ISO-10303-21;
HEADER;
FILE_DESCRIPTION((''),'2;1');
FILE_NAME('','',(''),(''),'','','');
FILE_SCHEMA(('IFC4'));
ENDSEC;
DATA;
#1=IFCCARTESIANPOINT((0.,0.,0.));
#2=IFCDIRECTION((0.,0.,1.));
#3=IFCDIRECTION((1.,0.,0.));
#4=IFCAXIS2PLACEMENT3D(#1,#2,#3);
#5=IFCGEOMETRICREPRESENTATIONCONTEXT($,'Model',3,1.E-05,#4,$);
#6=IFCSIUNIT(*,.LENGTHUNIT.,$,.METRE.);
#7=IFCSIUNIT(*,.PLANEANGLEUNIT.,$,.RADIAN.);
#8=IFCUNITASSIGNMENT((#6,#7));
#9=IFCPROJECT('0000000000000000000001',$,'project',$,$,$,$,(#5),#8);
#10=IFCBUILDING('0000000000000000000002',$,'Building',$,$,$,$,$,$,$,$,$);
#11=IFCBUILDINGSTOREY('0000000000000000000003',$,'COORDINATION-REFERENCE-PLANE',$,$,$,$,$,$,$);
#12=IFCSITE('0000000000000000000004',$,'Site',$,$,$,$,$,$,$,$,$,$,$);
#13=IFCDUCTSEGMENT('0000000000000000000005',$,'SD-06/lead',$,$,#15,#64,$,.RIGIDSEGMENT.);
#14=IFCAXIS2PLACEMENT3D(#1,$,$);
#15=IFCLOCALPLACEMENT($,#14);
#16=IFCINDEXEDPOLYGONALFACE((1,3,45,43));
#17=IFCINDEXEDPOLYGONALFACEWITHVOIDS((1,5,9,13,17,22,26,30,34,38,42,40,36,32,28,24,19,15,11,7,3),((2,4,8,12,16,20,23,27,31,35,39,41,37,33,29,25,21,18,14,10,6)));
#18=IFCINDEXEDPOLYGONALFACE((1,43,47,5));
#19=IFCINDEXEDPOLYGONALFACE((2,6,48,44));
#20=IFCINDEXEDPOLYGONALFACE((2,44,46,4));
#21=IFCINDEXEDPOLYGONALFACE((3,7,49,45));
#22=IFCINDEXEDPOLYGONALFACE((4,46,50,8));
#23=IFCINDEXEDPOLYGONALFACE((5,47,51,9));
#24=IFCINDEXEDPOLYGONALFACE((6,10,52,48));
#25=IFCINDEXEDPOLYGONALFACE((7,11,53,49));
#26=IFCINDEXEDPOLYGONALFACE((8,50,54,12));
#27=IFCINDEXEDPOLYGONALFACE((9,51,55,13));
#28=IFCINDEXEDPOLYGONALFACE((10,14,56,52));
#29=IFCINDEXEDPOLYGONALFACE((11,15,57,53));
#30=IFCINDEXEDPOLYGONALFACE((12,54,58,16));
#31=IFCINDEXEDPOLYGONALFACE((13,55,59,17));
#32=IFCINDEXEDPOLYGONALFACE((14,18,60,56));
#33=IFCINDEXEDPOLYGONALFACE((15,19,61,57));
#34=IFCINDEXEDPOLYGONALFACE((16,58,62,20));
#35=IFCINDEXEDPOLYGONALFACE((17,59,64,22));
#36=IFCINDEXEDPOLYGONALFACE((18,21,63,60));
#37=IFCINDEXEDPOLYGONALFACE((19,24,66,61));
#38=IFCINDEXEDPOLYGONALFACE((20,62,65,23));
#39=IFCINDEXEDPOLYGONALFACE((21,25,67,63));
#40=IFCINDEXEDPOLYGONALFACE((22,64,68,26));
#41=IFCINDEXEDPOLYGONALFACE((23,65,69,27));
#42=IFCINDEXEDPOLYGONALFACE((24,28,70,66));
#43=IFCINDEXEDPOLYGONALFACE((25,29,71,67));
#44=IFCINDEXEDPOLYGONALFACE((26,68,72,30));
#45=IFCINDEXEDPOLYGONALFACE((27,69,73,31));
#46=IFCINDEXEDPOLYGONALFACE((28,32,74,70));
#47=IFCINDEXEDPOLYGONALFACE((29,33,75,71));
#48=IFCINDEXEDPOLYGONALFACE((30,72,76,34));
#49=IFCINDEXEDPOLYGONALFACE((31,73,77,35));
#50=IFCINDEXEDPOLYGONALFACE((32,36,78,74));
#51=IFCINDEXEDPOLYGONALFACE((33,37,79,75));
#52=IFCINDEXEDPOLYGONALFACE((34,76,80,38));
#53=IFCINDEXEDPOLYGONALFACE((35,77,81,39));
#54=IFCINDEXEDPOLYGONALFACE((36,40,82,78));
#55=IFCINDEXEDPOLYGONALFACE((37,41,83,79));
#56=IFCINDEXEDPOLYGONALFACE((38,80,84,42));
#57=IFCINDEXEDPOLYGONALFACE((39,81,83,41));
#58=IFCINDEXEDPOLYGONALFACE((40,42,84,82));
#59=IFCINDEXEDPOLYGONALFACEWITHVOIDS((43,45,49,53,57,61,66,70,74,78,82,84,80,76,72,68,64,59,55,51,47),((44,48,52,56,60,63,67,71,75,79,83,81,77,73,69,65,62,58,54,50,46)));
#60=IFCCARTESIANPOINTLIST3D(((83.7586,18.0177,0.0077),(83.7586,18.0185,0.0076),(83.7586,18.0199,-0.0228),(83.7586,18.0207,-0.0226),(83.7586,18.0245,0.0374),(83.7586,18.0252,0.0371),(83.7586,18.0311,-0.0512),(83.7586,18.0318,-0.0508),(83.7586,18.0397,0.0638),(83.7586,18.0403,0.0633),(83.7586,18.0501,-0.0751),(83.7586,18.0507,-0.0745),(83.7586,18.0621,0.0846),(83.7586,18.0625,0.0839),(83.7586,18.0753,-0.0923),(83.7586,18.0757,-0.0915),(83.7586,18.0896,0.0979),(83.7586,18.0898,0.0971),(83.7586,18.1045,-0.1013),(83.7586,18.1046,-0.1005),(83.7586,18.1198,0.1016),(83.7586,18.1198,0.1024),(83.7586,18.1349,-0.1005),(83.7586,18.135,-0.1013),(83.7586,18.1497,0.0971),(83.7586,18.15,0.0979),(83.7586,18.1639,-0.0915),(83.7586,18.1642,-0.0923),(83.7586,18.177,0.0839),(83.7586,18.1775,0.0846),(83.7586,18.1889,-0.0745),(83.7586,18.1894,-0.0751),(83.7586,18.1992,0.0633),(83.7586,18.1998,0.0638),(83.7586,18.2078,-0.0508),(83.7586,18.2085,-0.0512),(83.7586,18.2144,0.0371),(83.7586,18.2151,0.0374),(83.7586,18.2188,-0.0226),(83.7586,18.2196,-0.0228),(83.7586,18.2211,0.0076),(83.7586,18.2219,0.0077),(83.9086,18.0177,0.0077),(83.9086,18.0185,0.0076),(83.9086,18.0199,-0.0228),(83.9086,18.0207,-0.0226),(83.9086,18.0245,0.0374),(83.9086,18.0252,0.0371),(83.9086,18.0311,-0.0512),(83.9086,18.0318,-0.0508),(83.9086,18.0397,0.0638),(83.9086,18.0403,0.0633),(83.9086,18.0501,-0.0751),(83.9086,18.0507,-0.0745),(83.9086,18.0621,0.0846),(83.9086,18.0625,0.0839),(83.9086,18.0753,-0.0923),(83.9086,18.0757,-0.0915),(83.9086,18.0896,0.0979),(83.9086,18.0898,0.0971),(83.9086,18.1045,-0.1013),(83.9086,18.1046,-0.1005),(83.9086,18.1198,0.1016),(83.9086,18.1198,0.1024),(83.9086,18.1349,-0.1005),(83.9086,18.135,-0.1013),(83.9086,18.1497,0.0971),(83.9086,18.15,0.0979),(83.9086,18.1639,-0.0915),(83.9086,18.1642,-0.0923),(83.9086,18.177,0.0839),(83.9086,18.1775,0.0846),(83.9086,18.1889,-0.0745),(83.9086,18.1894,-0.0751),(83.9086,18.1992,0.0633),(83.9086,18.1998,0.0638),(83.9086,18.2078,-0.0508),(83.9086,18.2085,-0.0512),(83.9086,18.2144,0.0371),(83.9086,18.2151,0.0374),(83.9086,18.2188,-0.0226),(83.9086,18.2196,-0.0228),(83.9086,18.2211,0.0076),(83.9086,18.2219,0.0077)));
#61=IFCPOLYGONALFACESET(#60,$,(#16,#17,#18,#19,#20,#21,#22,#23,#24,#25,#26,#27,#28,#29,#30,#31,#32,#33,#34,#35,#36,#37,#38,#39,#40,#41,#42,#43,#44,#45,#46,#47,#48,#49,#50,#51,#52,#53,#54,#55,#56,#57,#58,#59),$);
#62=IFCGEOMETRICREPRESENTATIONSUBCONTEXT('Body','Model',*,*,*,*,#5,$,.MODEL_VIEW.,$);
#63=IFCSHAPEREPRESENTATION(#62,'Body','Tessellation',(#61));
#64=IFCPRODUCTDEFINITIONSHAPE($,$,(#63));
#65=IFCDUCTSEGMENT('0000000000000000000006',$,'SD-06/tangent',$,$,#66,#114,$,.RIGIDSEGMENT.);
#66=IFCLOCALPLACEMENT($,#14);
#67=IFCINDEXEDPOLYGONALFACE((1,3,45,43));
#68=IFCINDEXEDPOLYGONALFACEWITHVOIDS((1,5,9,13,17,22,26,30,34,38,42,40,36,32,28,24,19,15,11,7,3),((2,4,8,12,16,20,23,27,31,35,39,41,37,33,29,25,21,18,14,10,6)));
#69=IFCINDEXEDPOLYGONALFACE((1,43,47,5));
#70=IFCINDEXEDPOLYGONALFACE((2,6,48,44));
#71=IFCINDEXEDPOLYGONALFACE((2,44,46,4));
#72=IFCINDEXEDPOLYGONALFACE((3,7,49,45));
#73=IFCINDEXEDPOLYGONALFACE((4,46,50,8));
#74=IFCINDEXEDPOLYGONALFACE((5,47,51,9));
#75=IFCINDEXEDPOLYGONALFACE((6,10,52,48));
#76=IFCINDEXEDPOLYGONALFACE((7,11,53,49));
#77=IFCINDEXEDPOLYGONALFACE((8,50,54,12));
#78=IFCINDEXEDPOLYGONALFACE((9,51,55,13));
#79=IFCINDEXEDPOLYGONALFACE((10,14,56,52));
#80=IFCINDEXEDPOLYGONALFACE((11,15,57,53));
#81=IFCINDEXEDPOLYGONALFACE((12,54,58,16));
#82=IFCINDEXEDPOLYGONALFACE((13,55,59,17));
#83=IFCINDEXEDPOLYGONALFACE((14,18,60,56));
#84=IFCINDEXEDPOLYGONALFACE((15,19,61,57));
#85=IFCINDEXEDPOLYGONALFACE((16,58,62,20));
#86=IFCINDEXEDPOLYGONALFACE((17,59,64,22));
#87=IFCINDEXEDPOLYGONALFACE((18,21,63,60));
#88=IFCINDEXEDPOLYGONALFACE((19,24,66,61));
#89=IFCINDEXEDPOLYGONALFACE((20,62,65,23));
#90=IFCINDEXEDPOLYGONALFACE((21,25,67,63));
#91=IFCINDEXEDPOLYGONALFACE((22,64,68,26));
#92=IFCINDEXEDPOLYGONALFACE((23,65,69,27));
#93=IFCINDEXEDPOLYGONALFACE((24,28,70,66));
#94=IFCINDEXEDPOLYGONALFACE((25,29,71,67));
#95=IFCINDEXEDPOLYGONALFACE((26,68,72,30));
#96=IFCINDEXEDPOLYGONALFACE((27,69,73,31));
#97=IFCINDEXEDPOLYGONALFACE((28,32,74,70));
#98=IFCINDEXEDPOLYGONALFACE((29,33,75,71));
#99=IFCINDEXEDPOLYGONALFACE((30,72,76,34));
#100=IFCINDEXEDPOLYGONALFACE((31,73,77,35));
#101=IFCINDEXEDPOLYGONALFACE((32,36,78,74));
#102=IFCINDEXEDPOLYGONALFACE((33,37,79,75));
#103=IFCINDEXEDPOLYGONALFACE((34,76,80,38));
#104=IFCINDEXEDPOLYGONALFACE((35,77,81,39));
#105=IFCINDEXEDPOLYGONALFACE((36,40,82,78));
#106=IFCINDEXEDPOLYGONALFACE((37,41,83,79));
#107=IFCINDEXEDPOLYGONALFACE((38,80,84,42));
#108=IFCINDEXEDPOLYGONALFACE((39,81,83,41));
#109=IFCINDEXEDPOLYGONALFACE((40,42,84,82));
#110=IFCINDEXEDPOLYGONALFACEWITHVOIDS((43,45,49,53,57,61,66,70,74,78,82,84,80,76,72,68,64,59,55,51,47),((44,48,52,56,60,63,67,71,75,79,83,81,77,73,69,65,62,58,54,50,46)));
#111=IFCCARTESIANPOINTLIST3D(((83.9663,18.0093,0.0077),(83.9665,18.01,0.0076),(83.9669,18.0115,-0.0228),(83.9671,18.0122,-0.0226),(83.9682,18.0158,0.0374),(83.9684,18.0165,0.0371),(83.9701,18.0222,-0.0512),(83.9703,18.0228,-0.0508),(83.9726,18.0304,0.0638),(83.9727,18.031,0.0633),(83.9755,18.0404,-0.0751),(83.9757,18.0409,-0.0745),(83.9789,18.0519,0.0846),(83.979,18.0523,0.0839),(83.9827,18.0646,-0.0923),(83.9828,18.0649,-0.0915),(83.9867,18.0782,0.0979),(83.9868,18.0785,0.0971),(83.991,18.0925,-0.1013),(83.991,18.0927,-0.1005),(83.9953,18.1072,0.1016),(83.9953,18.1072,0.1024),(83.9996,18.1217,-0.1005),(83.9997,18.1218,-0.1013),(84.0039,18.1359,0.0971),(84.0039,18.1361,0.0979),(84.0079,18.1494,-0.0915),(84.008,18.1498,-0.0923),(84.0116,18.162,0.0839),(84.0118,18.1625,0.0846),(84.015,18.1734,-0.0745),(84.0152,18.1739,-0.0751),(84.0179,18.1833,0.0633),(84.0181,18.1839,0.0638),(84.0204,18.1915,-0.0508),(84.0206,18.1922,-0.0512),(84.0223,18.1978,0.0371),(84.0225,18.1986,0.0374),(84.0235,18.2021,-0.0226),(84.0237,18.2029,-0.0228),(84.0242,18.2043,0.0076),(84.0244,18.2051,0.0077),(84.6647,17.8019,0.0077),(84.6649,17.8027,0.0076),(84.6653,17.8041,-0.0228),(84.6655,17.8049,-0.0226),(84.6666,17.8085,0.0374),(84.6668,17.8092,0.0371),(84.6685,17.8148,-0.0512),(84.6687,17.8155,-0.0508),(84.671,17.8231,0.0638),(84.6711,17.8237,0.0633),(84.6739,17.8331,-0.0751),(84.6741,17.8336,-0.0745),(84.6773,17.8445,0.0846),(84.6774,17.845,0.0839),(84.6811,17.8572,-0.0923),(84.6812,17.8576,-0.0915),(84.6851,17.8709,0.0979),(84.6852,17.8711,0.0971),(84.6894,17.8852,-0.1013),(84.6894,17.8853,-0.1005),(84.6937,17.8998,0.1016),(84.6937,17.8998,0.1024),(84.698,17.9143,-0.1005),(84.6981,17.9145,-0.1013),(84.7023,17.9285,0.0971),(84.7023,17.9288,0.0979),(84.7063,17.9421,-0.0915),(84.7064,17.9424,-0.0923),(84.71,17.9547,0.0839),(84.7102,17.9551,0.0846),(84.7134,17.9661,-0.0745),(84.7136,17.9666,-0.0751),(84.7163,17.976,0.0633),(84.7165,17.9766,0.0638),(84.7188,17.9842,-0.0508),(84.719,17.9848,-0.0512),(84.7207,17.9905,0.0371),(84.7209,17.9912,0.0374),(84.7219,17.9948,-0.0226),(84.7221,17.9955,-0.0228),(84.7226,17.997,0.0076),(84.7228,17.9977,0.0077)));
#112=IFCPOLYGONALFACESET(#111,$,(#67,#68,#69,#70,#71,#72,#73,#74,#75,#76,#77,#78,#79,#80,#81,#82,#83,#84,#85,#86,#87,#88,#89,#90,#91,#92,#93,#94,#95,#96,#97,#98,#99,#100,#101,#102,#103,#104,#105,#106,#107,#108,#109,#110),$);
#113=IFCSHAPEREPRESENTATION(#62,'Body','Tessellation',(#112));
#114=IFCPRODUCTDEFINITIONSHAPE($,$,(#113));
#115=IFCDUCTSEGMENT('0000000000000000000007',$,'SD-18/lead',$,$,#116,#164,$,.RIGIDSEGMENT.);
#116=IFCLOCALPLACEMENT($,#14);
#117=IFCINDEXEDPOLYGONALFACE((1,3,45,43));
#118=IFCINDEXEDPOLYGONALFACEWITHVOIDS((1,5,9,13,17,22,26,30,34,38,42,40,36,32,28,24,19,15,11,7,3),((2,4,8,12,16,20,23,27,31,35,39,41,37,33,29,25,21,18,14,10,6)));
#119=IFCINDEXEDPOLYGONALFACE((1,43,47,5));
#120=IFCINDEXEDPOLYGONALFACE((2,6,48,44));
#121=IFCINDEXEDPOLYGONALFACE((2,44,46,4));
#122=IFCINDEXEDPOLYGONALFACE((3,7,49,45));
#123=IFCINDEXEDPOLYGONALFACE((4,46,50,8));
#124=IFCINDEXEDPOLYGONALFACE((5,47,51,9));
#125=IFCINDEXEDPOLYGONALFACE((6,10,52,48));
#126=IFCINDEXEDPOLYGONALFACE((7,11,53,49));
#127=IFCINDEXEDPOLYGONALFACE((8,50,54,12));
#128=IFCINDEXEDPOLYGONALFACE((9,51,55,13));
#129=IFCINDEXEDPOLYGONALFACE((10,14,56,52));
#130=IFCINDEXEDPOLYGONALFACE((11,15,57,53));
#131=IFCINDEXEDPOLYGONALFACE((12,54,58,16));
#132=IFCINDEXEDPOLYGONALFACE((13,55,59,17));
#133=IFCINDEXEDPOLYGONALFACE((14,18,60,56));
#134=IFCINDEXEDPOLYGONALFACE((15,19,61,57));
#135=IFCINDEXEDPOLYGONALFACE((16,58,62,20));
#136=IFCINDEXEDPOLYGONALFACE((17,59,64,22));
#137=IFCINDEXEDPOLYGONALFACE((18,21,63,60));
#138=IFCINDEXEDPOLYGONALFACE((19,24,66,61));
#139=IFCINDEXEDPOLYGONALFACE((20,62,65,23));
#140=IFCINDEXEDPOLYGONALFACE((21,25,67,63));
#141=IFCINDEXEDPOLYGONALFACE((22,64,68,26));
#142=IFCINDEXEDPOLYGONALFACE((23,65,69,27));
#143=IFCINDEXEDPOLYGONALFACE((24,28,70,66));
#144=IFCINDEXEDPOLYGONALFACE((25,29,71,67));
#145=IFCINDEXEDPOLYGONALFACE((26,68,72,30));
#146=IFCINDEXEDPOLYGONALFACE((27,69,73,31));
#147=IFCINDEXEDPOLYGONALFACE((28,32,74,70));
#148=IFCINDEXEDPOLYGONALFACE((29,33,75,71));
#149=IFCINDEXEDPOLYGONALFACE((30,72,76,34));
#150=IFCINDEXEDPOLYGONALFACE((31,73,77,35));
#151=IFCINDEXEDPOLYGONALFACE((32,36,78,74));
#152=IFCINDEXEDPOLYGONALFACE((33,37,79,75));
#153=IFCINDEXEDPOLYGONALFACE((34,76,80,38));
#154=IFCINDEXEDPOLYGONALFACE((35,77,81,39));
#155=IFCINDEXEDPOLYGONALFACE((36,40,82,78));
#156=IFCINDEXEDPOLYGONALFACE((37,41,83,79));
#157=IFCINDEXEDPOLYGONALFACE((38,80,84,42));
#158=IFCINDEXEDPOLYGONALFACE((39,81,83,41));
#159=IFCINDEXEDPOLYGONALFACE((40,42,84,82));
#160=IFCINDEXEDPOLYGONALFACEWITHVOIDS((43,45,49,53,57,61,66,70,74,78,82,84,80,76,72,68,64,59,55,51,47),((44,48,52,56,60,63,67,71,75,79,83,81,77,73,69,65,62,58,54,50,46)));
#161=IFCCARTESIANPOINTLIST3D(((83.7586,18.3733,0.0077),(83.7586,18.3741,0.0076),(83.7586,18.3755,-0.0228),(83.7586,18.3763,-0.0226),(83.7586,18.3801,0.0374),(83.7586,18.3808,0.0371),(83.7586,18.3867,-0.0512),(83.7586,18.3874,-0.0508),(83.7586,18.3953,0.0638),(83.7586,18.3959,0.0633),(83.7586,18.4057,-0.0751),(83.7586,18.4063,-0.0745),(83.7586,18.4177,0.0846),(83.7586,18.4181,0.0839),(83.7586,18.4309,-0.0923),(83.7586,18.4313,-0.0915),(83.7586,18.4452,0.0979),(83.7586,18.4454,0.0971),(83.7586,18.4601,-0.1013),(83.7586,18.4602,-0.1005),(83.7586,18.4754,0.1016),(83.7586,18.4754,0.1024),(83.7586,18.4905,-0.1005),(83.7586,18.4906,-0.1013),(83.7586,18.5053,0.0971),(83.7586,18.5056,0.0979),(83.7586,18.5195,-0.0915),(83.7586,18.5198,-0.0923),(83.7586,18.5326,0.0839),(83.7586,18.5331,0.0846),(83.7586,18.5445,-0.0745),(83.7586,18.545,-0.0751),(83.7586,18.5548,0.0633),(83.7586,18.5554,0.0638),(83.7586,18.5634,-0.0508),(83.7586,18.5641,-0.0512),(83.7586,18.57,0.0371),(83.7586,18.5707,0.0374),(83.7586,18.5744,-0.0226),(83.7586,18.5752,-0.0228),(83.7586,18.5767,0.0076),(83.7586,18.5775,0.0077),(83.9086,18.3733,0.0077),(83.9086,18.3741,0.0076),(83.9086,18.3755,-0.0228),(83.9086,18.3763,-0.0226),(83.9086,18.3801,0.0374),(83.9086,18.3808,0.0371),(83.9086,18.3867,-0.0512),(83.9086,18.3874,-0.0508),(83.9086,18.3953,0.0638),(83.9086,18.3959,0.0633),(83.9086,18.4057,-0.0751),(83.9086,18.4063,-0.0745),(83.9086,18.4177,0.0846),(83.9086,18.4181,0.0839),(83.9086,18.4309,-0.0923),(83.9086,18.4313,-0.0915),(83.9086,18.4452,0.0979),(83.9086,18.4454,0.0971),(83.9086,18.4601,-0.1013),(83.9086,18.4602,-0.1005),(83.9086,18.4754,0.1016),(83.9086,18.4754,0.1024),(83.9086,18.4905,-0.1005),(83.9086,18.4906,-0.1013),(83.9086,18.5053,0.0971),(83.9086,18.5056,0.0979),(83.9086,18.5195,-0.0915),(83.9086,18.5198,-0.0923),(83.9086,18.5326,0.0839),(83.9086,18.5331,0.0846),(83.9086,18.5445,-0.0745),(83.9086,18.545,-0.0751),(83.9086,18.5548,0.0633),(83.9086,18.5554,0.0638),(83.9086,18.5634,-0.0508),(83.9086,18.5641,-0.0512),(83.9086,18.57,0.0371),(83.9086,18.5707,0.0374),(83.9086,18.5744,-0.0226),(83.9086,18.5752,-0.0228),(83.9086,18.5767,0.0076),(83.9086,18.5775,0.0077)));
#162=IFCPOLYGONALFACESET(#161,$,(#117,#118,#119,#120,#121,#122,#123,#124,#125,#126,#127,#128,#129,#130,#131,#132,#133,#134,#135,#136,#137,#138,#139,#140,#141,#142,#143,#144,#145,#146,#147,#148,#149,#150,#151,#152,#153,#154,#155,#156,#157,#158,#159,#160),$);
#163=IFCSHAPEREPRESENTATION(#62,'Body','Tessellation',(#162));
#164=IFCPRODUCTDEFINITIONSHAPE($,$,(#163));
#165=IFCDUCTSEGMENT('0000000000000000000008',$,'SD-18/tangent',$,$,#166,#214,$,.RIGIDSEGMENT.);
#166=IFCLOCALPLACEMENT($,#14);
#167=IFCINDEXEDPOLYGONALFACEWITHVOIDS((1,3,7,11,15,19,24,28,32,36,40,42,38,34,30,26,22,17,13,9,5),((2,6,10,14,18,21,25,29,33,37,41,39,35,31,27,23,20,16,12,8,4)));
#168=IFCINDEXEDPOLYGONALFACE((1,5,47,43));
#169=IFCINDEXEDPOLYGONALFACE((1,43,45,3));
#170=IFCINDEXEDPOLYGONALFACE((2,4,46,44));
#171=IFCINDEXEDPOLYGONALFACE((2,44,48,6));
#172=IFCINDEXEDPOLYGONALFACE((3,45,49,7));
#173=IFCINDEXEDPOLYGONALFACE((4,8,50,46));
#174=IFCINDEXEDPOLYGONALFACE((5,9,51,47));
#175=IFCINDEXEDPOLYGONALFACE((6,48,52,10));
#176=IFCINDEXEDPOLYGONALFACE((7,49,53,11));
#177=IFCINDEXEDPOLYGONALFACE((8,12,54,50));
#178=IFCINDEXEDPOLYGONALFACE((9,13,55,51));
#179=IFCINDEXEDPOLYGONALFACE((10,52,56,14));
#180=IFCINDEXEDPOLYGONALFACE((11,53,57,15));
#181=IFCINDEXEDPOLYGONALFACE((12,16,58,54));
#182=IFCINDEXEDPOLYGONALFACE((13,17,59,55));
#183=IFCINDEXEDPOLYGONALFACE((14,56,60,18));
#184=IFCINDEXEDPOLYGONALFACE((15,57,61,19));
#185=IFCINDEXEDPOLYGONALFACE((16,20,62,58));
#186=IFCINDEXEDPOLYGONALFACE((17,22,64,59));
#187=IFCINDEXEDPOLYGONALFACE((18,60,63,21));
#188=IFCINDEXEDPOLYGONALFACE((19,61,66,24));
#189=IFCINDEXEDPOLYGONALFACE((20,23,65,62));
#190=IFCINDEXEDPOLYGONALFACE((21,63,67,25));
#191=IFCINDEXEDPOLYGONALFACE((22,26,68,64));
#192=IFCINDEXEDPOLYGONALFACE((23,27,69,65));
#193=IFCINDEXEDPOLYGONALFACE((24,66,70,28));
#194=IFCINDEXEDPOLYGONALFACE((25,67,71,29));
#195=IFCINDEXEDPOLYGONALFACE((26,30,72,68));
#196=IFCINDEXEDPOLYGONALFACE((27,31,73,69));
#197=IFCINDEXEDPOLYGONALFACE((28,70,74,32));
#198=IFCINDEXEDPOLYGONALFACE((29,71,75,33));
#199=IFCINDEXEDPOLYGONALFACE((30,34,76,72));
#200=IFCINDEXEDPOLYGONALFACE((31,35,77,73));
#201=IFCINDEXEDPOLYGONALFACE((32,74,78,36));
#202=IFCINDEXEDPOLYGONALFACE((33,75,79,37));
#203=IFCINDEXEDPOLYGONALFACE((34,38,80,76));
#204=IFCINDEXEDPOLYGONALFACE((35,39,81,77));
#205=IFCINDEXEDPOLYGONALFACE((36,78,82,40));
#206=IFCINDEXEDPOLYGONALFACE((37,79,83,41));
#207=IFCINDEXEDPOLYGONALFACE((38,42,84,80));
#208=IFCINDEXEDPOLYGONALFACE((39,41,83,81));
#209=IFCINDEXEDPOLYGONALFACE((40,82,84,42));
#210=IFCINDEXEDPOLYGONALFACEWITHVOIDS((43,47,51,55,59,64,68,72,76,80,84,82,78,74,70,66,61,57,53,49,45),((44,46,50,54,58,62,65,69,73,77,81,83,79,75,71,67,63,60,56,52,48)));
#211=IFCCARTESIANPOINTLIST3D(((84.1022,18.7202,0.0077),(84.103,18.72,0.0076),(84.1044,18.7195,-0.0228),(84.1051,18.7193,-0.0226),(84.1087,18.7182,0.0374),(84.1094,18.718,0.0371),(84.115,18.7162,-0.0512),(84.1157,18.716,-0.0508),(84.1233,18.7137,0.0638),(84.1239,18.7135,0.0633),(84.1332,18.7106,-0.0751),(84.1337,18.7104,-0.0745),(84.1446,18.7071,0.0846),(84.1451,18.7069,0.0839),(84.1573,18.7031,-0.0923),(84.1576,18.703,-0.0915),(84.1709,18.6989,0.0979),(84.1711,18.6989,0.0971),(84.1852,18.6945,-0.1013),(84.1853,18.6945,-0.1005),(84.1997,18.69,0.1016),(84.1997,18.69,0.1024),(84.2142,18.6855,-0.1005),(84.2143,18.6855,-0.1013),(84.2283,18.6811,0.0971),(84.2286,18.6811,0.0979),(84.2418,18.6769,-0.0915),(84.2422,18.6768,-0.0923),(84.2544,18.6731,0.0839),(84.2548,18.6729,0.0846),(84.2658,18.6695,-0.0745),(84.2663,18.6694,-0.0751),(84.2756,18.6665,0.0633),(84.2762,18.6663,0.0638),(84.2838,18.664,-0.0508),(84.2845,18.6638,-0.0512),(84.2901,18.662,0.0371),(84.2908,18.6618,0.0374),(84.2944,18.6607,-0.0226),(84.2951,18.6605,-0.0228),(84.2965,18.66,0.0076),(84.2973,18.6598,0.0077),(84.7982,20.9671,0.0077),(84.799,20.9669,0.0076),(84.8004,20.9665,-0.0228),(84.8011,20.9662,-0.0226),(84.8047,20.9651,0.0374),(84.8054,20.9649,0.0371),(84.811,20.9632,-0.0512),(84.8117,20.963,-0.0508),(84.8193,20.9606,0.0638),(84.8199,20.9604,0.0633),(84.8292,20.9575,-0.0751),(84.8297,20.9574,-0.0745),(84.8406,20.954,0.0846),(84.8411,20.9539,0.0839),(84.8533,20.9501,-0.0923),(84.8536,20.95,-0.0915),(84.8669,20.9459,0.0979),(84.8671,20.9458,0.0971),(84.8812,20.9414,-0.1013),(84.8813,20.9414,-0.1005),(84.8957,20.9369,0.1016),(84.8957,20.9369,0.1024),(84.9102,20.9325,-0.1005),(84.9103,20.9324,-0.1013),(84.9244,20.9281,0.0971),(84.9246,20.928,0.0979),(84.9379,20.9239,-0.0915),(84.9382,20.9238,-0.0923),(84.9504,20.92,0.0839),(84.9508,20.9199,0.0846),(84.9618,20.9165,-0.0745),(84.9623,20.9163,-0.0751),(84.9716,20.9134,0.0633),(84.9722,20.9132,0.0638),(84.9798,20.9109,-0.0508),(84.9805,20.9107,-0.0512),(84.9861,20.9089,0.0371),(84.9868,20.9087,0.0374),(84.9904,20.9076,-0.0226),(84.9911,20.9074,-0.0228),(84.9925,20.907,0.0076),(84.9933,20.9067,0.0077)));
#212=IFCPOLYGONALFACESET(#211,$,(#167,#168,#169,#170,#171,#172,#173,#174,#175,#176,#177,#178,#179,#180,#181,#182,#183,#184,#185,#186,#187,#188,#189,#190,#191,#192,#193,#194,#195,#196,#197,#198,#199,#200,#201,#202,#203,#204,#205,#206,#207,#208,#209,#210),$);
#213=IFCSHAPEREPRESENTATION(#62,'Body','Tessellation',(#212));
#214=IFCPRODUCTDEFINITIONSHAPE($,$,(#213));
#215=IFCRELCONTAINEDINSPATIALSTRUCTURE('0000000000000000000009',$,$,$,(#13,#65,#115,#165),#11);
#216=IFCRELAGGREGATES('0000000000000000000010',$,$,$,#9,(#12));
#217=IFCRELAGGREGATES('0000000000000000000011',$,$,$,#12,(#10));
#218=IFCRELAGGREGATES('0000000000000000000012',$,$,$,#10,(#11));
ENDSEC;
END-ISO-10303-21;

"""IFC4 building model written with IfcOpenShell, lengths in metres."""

from ifc_helpers import new_model, si_unit, frame, origin_with_axes, place, context, subcontext, project, spatial, hollow_circle, extrude, element, save


model = new_model("IFC4")

# Units and contexts
model_context = context("Model", 3, precision=1e-05, world=origin_with_axes())
body_context_1 = subcontext(model_context, "Body", "Model", "MODEL_VIEW")
ifc_project = project(units=[si_unit("LENGTHUNIT", "METRE"), si_unit("PLANEANGLEUNIT", "RADIAN")], contexts=[model_context])

# Site, building, storey
site = spatial("IfcSite", under=ifc_project, Name="Site")
building = spatial("IfcBuilding", under=site, Name="Building")
storey = spatial("IfcBuildingStorey", under=building, Name="COORDINATION-REFERENCE-PLANE")

# Duct segment
duct_segment_1_placement = place(None, frame((83.7586, 18.1198, 0.0), z_axis=(1.0, 0.0, 0.0), x_axis=(0.0, 0.0, 1.0)))
element("IfcDuctSegment", 1, at=duct_segment_1_placement, inside=storey, Name="SD-06/lead", PredefinedType="RIGIDSEGMENT", context=body_context_1, shape_type="SweptSolid", body=[
    extrude(hollow_circle(Radius=0.1024, WallThickness=0.0008), origin_with_axes(), (0.0, 0.0, 1.0), 0.15),
])

# Duct segment
duct_segment_2_placement = place(None, frame((83.9953, 18.1072, 0.0), z_axis=(0.958645, -0.284603, 0.0), x_axis=(0.0, 0.0, 1.0)))
element("IfcDuctSegment", 2, at=duct_segment_2_placement, inside=storey, Name="SD-06/tangent", PredefinedType="RIGIDSEGMENT", context=body_context_1, shape_type="SweptSolid", body=[
    extrude(hollow_circle(Radius=0.1024, WallThickness=0.0008), origin_with_axes(), (0.0, 0.0, 1.0), 0.7285),
])

# Duct segment
duct_segment_3_placement = place(None, frame((83.7586, 18.4754, 0.0), z_axis=(1.0, 0.0, 0.0), x_axis=(0.0, 0.0, 1.0)))
element("IfcDuctSegment", 3, at=duct_segment_3_placement, inside=storey, Name="SD-18/lead", PredefinedType="RIGIDSEGMENT", context=body_context_1, shape_type="SweptSolid", body=[
    extrude(hollow_circle(Radius=0.1024, WallThickness=0.0008), origin_with_axes(), (0.0, 0.0, 1.0), 0.15),
])

# Duct segment
duct_segment_4_placement = place(None, frame((84.1997, 18.69, 0.0), z_axis=(0.295887, 0.955223, 0.0), x_axis=(0.0, 0.0, 1.0)))
element("IfcDuctSegment", 4, at=duct_segment_4_placement, inside=storey, Name="SD-18/tangent", PredefinedType="RIGIDSEGMENT", context=body_context_1, shape_type="SweptSolid", body=[
    extrude(hollow_circle(Radius=0.1024, WallThickness=0.0008), origin_with_axes(), (0.0, 0.0, 1.0), 2.3523),
])

save(model, "model.ifc")
